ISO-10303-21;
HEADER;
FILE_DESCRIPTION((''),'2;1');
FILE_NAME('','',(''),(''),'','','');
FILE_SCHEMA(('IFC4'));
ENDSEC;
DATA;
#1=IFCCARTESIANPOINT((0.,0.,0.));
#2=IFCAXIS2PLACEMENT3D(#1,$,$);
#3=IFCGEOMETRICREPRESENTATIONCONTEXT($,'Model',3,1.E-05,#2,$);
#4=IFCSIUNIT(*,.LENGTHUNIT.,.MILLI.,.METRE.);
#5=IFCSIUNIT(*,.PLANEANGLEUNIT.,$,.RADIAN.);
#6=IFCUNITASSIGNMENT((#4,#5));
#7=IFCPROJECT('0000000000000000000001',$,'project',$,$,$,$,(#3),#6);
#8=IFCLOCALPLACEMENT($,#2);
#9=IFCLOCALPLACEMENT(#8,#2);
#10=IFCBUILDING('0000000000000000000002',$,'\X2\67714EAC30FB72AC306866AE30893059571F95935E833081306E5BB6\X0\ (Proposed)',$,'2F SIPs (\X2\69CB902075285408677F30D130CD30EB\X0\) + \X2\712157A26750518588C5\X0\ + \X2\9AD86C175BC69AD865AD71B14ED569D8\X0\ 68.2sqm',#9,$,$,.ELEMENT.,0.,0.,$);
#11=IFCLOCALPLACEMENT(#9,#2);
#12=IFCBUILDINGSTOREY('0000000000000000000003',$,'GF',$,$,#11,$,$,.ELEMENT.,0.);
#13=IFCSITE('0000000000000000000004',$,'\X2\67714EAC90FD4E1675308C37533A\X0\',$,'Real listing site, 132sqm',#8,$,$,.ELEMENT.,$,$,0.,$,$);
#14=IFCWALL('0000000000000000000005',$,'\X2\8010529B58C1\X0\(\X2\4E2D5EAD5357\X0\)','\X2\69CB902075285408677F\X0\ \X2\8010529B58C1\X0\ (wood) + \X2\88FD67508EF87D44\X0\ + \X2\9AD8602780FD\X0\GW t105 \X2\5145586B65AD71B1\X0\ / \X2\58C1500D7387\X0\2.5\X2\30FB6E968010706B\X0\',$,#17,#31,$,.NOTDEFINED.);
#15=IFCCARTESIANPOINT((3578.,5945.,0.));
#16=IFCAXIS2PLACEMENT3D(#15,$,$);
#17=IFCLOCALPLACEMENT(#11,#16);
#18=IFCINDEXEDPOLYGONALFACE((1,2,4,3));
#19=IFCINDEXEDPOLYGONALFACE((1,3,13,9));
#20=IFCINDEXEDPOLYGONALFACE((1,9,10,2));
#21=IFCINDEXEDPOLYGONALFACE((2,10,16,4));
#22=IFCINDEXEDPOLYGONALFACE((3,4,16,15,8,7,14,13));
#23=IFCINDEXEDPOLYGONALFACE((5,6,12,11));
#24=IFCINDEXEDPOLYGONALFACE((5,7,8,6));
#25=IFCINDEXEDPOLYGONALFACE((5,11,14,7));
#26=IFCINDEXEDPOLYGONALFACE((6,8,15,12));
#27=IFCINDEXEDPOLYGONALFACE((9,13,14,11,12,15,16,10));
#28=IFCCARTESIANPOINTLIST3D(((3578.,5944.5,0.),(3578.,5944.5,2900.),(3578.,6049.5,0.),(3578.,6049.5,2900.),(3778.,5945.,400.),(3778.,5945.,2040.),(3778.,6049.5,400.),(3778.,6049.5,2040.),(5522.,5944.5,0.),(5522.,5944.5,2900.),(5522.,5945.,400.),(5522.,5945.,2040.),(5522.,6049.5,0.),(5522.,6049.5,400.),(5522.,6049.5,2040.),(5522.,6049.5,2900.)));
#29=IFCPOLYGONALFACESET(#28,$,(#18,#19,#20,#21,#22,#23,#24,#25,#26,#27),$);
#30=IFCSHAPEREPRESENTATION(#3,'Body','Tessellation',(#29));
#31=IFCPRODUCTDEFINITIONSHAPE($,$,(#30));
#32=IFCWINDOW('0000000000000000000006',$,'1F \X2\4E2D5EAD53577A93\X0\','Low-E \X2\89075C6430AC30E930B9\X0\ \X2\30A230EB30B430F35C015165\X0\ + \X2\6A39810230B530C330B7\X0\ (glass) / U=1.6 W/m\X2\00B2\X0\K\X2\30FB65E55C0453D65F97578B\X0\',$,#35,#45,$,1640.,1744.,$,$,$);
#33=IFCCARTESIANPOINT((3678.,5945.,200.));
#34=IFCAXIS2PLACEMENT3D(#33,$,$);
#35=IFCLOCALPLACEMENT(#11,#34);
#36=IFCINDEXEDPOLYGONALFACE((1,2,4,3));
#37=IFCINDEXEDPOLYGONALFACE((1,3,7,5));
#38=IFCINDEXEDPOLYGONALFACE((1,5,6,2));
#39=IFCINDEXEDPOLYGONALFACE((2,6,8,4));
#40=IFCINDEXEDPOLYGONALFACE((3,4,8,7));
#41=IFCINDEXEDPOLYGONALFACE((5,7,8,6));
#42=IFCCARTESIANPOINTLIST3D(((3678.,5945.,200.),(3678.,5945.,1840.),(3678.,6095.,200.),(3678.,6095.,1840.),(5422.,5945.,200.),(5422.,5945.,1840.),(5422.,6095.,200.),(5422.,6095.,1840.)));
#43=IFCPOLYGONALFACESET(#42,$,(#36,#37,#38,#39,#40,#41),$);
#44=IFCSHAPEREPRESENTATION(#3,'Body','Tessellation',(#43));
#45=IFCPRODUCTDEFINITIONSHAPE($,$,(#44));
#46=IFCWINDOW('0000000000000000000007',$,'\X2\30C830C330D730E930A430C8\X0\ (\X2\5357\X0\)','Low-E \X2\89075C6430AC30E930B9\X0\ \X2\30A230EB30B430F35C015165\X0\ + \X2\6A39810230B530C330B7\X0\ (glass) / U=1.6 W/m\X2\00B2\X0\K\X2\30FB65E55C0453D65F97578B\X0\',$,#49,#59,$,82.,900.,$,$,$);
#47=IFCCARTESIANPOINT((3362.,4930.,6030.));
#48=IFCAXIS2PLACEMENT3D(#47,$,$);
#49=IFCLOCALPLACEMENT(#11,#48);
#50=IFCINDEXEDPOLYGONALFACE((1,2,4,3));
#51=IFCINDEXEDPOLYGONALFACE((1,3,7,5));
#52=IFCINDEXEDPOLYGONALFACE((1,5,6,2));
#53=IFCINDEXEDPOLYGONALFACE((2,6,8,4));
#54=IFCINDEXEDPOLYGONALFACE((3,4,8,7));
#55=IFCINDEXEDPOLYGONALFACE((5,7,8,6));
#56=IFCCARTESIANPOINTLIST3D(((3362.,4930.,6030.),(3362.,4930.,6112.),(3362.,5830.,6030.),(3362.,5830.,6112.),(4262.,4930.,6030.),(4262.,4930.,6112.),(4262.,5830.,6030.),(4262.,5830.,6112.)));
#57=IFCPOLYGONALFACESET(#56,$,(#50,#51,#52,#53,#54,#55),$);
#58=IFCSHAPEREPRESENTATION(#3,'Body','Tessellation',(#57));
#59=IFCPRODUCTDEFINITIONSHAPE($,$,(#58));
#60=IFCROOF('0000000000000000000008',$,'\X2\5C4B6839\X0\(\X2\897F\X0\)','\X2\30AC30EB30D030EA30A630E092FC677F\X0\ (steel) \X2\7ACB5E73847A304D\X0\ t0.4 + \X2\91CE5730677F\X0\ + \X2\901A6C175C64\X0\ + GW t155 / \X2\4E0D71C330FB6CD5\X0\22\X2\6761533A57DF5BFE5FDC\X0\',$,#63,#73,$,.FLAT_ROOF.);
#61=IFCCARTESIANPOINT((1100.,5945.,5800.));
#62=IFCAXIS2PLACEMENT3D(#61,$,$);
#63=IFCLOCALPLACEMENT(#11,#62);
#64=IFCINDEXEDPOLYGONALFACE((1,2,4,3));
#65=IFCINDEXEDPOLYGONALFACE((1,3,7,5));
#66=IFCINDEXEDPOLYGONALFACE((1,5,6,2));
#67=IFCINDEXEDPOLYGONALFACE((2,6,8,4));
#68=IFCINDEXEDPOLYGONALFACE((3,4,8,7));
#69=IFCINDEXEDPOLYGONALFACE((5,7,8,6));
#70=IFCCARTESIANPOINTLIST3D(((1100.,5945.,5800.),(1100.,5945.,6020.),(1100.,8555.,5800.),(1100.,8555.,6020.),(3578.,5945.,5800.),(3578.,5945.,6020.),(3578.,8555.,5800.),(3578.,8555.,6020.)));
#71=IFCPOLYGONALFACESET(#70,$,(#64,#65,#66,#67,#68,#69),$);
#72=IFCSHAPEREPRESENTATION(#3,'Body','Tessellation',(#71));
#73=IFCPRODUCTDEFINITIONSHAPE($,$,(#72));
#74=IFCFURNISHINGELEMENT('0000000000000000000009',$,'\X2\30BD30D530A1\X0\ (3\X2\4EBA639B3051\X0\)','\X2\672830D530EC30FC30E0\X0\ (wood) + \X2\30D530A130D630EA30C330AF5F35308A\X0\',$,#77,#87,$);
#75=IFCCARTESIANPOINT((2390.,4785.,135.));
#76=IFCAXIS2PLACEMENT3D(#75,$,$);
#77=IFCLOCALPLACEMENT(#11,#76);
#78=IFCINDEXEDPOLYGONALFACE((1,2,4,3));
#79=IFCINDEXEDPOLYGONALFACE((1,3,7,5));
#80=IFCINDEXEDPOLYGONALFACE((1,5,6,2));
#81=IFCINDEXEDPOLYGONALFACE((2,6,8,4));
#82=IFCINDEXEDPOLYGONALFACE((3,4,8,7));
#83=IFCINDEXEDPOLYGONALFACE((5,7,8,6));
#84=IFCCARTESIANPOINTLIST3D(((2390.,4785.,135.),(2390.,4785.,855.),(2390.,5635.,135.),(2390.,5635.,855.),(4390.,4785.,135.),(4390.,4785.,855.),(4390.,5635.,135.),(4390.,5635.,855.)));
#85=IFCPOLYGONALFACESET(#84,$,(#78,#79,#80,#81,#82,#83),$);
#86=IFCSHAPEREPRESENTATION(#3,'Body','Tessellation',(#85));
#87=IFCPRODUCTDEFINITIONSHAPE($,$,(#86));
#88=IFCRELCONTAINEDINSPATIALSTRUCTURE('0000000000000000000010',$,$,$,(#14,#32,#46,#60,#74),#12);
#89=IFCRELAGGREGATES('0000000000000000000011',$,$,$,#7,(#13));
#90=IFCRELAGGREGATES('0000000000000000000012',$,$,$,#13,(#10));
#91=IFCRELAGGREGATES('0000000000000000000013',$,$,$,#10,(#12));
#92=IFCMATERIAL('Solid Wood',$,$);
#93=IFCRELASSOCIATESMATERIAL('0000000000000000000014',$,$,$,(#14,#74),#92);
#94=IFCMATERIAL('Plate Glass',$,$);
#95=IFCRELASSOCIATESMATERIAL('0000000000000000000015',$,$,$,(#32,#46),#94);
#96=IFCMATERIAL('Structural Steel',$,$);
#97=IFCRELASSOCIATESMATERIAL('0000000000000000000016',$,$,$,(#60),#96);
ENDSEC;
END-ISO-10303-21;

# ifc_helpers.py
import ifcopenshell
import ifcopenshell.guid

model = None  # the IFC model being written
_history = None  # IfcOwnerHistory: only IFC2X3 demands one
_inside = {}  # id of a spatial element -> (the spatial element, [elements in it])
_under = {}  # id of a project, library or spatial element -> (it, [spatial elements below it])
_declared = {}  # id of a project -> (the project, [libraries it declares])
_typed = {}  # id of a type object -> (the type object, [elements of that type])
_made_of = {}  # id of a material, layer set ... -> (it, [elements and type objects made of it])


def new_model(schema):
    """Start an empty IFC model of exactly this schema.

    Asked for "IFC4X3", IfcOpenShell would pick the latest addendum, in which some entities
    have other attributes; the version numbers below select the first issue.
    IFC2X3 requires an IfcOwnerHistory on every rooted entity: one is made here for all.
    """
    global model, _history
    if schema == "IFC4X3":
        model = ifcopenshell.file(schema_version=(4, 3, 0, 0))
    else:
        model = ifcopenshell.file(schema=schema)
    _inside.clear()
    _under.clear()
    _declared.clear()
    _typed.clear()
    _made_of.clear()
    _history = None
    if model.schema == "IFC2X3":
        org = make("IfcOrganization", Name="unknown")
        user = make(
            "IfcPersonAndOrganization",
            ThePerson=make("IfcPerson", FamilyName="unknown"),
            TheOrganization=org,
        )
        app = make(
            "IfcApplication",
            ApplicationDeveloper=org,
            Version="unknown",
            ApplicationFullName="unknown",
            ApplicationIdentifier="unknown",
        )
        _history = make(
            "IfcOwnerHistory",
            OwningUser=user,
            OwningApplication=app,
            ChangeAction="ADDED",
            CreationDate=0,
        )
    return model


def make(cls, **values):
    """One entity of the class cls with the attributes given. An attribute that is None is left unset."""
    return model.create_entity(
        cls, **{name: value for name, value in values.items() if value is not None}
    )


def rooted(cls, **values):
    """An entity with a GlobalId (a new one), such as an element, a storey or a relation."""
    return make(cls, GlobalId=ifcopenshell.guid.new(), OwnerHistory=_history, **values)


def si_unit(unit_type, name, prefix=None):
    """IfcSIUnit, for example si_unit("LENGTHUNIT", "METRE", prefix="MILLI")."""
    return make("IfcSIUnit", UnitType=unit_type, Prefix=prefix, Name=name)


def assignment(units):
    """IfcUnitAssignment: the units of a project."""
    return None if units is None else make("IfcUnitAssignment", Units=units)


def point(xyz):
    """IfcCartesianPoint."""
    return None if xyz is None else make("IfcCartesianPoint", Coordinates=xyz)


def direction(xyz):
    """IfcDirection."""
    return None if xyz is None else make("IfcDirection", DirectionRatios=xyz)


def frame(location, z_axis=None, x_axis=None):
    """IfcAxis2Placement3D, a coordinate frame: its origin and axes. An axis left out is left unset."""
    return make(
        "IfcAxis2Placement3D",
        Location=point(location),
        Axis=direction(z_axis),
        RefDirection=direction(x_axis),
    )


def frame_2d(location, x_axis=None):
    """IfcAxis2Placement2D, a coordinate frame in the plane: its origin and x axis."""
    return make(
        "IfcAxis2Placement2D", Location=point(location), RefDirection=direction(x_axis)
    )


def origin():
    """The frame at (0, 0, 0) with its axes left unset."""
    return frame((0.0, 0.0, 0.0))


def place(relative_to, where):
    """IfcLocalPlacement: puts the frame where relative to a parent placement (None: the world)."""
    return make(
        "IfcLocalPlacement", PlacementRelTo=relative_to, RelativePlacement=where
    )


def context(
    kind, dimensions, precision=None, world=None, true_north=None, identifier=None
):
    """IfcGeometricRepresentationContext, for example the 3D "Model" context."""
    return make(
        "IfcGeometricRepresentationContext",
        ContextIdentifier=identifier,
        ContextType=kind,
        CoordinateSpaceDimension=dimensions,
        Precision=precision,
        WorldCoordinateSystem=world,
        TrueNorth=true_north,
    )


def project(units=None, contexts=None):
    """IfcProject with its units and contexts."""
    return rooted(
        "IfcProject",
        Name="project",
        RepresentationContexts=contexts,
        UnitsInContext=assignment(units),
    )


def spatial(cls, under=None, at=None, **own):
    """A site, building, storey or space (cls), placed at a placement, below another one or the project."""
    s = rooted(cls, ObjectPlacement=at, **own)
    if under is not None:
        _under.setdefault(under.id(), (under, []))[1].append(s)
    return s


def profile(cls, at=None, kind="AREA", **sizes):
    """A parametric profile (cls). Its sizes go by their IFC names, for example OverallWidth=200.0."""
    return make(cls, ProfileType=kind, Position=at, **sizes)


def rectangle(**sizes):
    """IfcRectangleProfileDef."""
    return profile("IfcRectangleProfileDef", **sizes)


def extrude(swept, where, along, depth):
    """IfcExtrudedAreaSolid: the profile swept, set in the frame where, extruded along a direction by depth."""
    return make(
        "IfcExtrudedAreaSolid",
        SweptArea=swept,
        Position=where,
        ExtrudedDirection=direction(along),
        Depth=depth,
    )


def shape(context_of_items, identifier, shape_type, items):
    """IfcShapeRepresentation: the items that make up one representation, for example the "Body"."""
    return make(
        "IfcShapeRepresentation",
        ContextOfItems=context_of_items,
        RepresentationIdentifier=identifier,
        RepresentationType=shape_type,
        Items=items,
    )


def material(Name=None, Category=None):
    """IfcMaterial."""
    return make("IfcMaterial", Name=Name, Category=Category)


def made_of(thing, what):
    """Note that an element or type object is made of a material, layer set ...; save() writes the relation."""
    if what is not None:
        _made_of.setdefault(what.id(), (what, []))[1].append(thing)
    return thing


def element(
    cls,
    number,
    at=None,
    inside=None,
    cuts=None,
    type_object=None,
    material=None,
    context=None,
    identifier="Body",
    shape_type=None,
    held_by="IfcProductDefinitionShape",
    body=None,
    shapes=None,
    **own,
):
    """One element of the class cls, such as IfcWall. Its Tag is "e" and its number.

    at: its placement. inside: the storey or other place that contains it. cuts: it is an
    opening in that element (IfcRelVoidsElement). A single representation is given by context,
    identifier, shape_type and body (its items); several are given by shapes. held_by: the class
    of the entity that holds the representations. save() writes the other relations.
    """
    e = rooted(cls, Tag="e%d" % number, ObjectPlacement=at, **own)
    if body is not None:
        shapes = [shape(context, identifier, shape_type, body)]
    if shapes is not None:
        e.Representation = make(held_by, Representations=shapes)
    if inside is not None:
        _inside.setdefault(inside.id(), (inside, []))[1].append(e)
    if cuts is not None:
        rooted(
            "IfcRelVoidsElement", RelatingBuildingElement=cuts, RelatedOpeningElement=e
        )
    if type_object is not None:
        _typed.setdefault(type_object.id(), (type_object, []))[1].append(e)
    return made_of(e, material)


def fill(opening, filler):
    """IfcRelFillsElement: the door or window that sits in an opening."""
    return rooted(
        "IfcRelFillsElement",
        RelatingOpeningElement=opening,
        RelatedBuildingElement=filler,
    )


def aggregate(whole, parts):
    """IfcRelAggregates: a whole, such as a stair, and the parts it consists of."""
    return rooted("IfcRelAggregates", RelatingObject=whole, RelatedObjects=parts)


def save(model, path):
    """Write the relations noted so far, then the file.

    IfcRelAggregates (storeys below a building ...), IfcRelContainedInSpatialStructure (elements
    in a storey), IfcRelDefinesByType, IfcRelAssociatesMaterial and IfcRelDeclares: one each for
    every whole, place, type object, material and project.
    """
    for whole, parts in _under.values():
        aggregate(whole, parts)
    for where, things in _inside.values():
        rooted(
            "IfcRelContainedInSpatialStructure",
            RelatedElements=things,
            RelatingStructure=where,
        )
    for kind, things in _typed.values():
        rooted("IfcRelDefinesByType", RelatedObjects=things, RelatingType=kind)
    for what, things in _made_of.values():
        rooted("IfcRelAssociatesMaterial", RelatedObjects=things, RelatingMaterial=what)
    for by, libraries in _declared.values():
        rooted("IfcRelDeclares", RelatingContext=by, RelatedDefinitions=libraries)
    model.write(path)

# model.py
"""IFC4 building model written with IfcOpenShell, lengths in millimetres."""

from ifc_helpers import new_model, si_unit, frame, frame_2d, origin, place, context, project, spatial, rectangle, extrude, material, element, fill, save


model = new_model("IFC4")

# Units and contexts
model_context = context("Model", 3, precision=1e-05, world=origin())
ifc_project = project(units=[si_unit("LENGTHUNIT", "METRE", prefix="MILLI"), si_unit("PLANEANGLEUNIT", "RADIAN")], contexts=[model_context])

# Site, building, storey
site_placement = place(None, origin())
site = spatial("IfcSite", under=ifc_project, at=site_placement, Name="東京都世田谷区", ObjectType="Real listing site, 132sqm", CompositionType="ELEMENT", RefElevation=0.0)
building_placement = place(site_placement, origin())
building = spatial("IfcBuilding", under=site, at=building_placement, Name="東京・犬と暮らす土間広めの家 (Proposed)", ObjectType="2F SIPs (構造用合板パネル) + 無垢材内装 + 高気密高断熱仕様 68.2sqm", CompositionType="ELEMENT", ElevationOfRefHeight=0.0, ElevationOfTerrain=0.0)
storey_placement = place(building_placement, origin())
storey = spatial("IfcBuildingStorey", under=building, at=storey_placement, Name="GF", CompositionType="ELEMENT", Elevation=0.0)

# Shared definitions
ifc_material_1 = material(Name="Solid Wood")

# Wall, opening, window
wall_placement = place(storey_placement, frame((3578.0, 5945.0, 0.0)))
wall = element("IfcWall", 1, at=wall_placement, inside=storey, material=ifc_material_1, Name="耐力壁(中庭南)", Description="構造用合板 耐力壁 (wood) + 製材軸組 + 高性能GW t105 充填断熱 / 壁倍率2.5・準耐火", PredefinedType="NOTDEFINED", context=model_context, shape_type="SweptSolid", body=[
    extrude(rectangle(XDim=1944.0, YDim=105.0, at=frame_2d((972.0, 52.0))), frame((3578.0, 5945.0, 0.0)), (0.0, 0.0, 1.0), 2900.0),
])
opening_placement = place(storey_placement, frame((3678.0, 5945.0, 200.0)))
opening = element("IfcOpeningElement", 2, at=opening_placement, cuts=wall, PredefinedType="NOTDEFINED", context=model_context, shape_type="SweptSolid", body=[
    extrude(rectangle(XDim=1744.0, YDim=150.0, at=frame_2d((872.0, 75.0))), frame((3678.0, 5945.0, 200.0)), (0.0, 0.0, 1.0), 1640.0),
])
ifc_material_2 = material(Name="Plate Glass")
window_1_placement = place(storey_placement, frame((3678.0, 5945.0, 200.0)))
window_1 = element("IfcWindow", 3, at=window_1_placement, inside=storey, material=ifc_material_2, Name="1F 中庭南窓", Description="Low-E 複層ガラス アルゴン封入 + 樹脂サッシ (glass) / U=1.6 W/m²K・日射取得型", OverallHeight=1640.0, OverallWidth=1744.0, context=model_context, shape_type="SweptSolid", body=[
    extrude(rectangle(XDim=1744.0, YDim=150.0, at=frame_2d((872.0, 75.0))), frame((3678.0, 5945.0, 200.0)), (0.0, 0.0, 1.0), 1640.0),
])
fill(opening, window_1)

# Window
window_2_placement = place(storey_placement, frame((3362.0, 4930.0, 6030.0)))
element("IfcWindow", 4, at=window_2_placement, inside=storey, material=ifc_material_2, Name="トップライト (南)", Description="Low-E 複層ガラス アルゴン封入 + 樹脂サッシ (glass) / U=1.6 W/m²K・日射取得型", OverallHeight=82.0, OverallWidth=900.0, context=model_context, shape_type="SweptSolid", body=[
    extrude(rectangle(XDim=900.0, YDim=900.0, at=frame_2d((450.0, 450.0))), frame((3362.0, 4930.0, 6030.0)), (0.0, 0.0, 1.0), 82.0),
])

# Roof
ifc_material_3 = material(Name="Structural Steel")
for number, where, name in (
    (5, (1100.0, 5945.0, 5800.0), "屋根(西)"),
):
    element("IfcRoof", number, at=place(storey_placement, frame(where)), inside=storey, material=ifc_material_3, Name=name, Description="ガルバリウム鋼板 (steel) 立平葺き t0.4 + 野地板 + 通気層 + GW t155 / 不燃・法22条区域対応", PredefinedType="FLAT_ROOF", context=model_context, shape_type="SweptSolid", body=[
        extrude(rectangle(XDim=2478.0, YDim=2610.0, at=frame_2d((1239.0, 1305.0))), frame((1100.0, 5945.0, 5800.0)), (0.0, 0.0, 1.0), 220.0),
    ])

# Furnishing element
furnishing_placement = place(storey_placement, frame((2390.0, 4785.0, 135.0)))
element("IfcFurnishingElement", 6, at=furnishing_placement, inside=storey, material=ifc_material_1, Name="ソファ (3人掛け)", Description="木フレーム (wood) + ファブリック張り", context=model_context, shape_type="SweptSolid", body=[
    extrude(rectangle(XDim=2000.0, YDim=850.0, at=frame_2d((1000.0, 425.0))), frame((2390.0, 4785.0, 135.0)), (0.0, 0.0, 1.0), 720.0),
])

save(model, "model.ifc")
